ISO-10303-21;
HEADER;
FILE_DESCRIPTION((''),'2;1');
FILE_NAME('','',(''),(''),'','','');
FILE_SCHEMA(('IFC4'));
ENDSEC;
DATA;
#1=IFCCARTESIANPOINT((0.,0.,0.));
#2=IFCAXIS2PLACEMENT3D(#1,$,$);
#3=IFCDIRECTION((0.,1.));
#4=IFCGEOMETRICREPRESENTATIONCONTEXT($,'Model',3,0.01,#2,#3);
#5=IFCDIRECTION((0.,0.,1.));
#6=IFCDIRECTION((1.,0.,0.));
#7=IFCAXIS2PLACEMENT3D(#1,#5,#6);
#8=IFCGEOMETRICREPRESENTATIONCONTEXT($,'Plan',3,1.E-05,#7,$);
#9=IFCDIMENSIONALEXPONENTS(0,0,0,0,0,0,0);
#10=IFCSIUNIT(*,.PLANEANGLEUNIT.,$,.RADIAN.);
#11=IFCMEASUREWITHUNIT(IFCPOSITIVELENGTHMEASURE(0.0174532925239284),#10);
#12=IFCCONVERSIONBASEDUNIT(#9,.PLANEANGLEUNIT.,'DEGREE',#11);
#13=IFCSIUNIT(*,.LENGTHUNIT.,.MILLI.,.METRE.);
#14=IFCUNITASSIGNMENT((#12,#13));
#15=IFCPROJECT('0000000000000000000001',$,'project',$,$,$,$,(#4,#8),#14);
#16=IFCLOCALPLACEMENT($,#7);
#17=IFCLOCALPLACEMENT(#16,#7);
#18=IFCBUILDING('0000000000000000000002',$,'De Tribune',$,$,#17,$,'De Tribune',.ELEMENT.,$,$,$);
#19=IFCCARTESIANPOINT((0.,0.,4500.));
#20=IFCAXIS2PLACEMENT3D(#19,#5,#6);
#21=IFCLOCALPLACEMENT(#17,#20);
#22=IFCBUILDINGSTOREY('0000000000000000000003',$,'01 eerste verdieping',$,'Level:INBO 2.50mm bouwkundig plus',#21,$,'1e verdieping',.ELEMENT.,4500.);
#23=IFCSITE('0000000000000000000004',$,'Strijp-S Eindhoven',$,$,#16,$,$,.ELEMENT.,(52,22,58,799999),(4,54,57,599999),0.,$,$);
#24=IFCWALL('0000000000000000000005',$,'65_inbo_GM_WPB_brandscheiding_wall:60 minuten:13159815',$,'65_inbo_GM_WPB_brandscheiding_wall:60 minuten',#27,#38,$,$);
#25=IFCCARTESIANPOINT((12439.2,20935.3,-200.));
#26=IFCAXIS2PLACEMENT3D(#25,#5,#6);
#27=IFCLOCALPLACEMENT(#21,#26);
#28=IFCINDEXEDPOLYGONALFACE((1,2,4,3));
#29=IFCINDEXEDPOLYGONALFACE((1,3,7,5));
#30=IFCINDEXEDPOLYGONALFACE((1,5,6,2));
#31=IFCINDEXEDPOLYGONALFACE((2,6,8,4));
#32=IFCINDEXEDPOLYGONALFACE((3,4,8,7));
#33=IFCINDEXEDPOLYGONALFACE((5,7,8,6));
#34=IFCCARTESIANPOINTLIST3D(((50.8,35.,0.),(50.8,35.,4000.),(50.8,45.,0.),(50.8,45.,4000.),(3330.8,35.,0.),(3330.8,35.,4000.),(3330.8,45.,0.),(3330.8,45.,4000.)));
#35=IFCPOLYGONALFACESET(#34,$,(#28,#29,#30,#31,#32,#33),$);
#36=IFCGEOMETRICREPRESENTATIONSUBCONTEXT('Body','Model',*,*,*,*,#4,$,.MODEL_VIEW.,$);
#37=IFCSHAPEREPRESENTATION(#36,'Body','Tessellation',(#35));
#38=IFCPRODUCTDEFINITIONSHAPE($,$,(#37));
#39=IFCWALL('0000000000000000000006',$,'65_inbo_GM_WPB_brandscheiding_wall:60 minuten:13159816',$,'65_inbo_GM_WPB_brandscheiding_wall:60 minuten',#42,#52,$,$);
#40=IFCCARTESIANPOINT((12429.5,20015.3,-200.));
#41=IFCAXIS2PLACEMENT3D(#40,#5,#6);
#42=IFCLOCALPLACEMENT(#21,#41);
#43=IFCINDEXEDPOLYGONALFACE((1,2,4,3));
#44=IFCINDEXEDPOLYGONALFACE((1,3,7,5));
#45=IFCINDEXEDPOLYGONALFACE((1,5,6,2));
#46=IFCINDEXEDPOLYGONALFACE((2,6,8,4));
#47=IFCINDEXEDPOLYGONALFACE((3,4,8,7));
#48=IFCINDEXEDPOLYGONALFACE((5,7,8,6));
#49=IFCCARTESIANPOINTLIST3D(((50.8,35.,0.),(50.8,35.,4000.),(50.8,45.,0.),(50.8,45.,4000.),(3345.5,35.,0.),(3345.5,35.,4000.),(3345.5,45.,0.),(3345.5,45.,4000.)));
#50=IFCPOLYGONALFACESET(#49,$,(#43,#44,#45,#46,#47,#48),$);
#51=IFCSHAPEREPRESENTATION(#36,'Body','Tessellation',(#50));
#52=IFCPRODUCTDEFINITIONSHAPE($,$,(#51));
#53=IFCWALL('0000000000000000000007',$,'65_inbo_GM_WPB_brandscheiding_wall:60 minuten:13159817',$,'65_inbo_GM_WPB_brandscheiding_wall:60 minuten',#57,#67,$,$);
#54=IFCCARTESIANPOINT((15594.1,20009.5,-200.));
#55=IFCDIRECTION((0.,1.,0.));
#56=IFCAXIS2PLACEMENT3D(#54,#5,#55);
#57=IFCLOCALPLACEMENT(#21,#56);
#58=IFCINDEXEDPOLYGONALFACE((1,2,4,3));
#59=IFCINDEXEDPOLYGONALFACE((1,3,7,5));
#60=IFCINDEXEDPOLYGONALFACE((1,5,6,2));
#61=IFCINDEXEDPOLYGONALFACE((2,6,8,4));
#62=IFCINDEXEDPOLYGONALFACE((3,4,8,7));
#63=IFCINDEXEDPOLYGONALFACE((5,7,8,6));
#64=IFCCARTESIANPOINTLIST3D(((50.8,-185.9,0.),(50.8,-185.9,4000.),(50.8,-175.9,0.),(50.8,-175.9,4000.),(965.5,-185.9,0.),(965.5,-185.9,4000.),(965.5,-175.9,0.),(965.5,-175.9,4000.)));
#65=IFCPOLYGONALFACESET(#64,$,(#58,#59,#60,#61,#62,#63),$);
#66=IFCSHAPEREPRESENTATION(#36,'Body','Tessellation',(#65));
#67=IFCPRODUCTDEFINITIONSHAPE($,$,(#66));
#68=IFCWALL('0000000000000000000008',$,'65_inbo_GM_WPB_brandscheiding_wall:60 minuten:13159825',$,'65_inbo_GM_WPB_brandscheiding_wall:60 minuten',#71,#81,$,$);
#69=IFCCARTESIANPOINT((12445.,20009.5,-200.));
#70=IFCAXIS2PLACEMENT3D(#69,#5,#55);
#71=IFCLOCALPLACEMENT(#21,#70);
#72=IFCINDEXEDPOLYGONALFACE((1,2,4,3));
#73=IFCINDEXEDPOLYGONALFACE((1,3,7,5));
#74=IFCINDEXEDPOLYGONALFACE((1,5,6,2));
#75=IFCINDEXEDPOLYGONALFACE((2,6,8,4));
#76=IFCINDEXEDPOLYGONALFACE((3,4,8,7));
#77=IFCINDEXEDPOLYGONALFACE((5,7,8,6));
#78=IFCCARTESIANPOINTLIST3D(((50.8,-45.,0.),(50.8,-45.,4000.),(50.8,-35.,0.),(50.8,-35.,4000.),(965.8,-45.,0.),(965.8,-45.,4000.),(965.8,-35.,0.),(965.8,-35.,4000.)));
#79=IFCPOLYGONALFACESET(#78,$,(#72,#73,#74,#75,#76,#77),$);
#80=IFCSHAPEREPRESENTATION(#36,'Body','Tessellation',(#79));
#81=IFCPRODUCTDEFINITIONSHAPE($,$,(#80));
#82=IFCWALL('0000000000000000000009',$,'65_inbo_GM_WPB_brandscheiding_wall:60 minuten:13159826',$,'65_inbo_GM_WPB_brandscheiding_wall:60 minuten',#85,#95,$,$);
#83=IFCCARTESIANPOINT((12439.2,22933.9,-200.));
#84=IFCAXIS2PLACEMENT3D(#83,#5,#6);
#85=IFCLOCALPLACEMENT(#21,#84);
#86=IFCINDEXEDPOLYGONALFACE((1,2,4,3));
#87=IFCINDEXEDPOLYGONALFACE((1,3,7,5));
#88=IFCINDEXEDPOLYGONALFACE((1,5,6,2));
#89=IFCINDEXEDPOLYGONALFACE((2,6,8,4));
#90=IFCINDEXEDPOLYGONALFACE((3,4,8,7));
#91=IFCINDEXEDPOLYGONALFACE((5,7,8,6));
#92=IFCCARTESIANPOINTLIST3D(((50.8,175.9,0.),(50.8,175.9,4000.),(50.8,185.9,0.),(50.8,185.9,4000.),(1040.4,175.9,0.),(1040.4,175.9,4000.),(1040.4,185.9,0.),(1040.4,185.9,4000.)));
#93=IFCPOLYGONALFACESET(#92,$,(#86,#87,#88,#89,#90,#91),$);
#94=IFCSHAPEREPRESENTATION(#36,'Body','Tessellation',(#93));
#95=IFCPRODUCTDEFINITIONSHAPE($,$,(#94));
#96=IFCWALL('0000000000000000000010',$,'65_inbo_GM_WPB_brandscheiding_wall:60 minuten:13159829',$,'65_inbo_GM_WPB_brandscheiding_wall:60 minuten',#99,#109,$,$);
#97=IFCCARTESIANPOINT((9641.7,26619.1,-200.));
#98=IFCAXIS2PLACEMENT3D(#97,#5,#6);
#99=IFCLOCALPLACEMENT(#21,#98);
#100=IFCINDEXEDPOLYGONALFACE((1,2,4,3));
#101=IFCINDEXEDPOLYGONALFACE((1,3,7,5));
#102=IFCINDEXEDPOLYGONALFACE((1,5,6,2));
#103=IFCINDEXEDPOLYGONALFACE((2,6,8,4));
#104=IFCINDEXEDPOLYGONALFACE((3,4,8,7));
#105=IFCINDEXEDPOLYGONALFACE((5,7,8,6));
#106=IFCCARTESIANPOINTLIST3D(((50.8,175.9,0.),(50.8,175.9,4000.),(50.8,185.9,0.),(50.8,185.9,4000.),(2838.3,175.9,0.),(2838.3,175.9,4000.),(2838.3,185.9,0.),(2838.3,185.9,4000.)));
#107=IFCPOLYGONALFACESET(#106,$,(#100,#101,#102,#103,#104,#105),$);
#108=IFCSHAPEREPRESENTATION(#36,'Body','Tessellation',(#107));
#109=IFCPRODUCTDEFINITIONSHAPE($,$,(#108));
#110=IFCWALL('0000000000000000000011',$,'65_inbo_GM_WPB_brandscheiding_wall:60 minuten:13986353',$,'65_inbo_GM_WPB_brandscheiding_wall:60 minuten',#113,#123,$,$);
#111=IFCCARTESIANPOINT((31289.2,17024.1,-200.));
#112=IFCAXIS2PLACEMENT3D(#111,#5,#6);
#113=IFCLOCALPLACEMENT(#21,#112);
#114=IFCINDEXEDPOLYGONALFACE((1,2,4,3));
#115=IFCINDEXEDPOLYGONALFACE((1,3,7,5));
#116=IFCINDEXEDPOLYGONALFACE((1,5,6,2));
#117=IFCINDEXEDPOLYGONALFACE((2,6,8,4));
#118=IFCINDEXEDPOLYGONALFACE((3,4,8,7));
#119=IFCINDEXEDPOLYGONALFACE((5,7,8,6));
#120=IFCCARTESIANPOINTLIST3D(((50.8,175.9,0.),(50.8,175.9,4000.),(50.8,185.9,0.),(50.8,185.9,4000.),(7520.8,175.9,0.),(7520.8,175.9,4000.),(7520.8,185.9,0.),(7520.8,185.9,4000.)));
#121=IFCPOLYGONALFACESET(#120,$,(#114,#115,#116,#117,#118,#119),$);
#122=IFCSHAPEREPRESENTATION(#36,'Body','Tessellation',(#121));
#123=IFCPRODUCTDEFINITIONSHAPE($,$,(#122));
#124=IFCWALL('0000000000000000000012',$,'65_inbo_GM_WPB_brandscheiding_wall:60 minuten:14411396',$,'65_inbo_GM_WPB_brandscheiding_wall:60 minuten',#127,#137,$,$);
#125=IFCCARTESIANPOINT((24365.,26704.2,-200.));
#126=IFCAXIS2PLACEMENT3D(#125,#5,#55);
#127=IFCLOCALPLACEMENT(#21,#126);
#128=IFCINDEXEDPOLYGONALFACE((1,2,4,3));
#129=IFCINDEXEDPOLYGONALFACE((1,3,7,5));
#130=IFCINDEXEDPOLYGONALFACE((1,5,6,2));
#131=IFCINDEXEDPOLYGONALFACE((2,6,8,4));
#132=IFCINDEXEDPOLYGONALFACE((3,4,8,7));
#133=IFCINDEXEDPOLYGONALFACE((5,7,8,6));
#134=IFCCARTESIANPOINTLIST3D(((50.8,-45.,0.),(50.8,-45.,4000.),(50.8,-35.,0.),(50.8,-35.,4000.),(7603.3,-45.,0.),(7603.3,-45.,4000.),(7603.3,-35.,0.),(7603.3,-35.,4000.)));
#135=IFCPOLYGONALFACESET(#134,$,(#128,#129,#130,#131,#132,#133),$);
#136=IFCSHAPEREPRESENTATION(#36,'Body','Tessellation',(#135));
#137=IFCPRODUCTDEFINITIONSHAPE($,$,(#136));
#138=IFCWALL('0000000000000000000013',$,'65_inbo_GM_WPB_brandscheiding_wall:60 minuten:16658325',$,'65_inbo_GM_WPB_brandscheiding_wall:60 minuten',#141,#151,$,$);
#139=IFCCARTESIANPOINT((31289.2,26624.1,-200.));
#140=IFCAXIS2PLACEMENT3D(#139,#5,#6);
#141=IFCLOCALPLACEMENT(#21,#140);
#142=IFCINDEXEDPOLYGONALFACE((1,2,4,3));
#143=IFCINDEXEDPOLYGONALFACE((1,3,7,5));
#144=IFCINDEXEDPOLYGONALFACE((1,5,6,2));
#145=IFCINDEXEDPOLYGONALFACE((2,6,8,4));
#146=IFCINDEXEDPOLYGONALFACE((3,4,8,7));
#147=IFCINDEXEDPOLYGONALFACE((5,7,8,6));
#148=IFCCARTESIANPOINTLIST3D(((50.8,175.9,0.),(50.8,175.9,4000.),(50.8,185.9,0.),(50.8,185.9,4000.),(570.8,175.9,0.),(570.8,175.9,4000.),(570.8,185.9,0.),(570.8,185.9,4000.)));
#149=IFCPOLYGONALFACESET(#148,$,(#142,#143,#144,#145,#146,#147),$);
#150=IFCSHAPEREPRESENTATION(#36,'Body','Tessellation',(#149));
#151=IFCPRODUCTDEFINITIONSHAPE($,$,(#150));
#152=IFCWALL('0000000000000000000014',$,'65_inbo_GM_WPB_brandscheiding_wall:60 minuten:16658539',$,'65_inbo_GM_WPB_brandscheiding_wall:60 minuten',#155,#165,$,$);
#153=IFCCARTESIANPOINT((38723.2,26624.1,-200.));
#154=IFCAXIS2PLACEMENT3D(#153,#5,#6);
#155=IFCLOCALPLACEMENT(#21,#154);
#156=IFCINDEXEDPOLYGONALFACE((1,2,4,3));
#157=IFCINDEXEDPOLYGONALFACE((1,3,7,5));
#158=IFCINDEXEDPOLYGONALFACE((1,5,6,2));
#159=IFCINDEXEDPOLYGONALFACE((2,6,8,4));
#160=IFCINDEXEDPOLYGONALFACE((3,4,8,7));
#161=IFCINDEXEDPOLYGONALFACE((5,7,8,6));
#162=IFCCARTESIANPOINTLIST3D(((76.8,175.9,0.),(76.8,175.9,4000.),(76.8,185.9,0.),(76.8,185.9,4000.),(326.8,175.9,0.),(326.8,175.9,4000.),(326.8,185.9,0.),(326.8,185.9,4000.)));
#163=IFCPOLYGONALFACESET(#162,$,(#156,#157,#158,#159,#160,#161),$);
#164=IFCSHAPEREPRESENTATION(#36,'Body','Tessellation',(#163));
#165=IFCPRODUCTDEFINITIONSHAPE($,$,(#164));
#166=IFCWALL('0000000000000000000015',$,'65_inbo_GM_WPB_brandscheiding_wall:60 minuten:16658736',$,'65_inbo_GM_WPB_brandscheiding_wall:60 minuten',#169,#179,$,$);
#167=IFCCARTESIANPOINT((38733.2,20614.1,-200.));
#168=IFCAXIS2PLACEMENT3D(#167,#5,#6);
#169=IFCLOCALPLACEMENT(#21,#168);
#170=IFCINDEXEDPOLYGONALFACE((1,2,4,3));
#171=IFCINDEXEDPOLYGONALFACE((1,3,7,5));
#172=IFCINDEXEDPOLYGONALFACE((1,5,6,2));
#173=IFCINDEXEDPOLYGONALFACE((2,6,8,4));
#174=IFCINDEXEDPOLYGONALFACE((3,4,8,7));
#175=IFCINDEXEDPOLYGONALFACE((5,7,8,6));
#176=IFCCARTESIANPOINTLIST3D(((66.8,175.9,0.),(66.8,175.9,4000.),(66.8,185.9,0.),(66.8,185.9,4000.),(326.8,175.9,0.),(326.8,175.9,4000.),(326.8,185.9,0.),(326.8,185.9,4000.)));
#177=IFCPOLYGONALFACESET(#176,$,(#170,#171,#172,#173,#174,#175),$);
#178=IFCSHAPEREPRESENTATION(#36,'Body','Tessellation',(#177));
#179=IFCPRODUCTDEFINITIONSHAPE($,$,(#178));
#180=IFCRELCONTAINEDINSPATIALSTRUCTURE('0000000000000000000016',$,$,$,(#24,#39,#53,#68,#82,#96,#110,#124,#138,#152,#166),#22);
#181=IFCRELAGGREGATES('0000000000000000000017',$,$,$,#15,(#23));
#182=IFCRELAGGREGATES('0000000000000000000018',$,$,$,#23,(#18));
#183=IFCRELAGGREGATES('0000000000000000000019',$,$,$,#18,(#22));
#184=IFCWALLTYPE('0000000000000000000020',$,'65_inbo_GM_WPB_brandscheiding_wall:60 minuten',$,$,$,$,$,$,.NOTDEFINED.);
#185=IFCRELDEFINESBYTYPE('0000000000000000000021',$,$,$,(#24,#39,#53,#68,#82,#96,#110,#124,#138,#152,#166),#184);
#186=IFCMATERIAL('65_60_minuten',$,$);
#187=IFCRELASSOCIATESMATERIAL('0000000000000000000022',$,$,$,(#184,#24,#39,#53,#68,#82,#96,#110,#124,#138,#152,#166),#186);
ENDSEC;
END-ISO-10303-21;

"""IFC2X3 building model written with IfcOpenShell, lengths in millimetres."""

from ifc_helpers import new_model, entity, si_unit, converted_unit, direction, frame, frame_2d, origin, origin_with_axes, origin_2d_with_axis, place, context, subcontext, project, spatial, rectangle, extrude, material, type_object, element, save


model = new_model("IFC2X3")

# Units and contexts
model_context = context("Model", 3, precision=0.01, world=origin(), true_north=direction((0.0, 1.0)))
plan_context = context("Plan", 3, precision=1e-05, world=origin_with_axes())
body_context = subcontext(model_context, "Body", "Model", "MODEL_VIEW")
ifc_project = project(units=[converted_unit("PLANEANGLEUNIT", "DEGREE", entity("IfcPositiveLengthMeasure", 0.0174532925239284), si_unit("PLANEANGLEUNIT", "RADIAN"), dimensions=[0, 0, 0, 0, 0, 0, 0]), si_unit("LENGTHUNIT", "METRE", prefix="MILLI")], contexts=[model_context, plan_context])

# Site, building, storey
site_placement = place(None, origin_with_axes())
site = spatial("IfcSite", under=ifc_project, at=site_placement, Name="Strijp-S Eindhoven", CompositionType="ELEMENT", RefLatitude=(52, 22, 58, 799999), RefLongitude=(4, 54, 57, 599999), RefElevation=0.0)
building_placement = place(site_placement, origin_with_axes())
building = spatial("IfcBuilding", under=site, at=building_placement, Name="De Tribune", LongName="De Tribune", CompositionType="ELEMENT")
storey_placement = place(building_placement, frame((0.0, 0.0, 4500.0), z_axis=(0.0, 0.0, 1.0), x_axis=(1.0, 0.0, 0.0)))
storey = spatial("IfcBuildingStorey", under=building, at=storey_placement, Name="01 eerste verdieping", ObjectType="Level:INBO 2.50mm bouwkundig plus", LongName="1e verdieping", CompositionType="ELEMENT", Elevation=4500.0)

# Walls
ifc_material_1 = material(Name="65_60_minuten")
wall_type_1 = type_object("IfcWallType", Name="65_inbo_GM_WPB_brandscheiding_wall:60 minuten", PredefinedType="NOTDEFINED", material=ifc_material_1)
wall_1_placement = place(storey_placement, frame((12439.2, 20935.3, -200.0), z_axis=(0.0, 0.0, 1.0), x_axis=(1.0, 0.0, 0.0)))
element("IfcWall", 1, at=wall_1_placement, inside=storey, type_object=wall_type_1, material=ifc_material_1, Name="65_inbo_GM_WPB_brandscheiding_wall:60 minuten:13159815", ObjectType="65_inbo_GM_WPB_brandscheiding_wall:60 minuten", context=body_context, shape_type="SweptSolid", body=[
    extrude(rectangle(XDim=10.0, YDim=3280.0, at=frame_2d((0.0, 0.0), x_axis=(1.0, 0.0))), frame((1690.8, 40.0, 0.0), z_axis=(0.0, 0.0, 1.0), x_axis=(0.0, 1.0, 0.0)), (0.0, 0.0, 1.0), 4000.0),
])
wall_2_placement = place(storey_placement, frame((12429.5, 20015.3, -200.0), z_axis=(0.0, 0.0, 1.0), x_axis=(1.0, 0.0, 0.0)))
element("IfcWall", 2, at=wall_2_placement, inside=storey, type_object=wall_type_1, material=ifc_material_1, Name="65_inbo_GM_WPB_brandscheiding_wall:60 minuten:13159816", ObjectType="65_inbo_GM_WPB_brandscheiding_wall:60 minuten", context=body_context, shape_type="SweptSolid", body=[
    extrude(rectangle(XDim=10.0, YDim=3294.7, at=frame_2d((0.0, 0.0), x_axis=(1.0, 0.0))), frame((1698.2, 40.0, 0.0), z_axis=(0.0, 0.0, 1.0), x_axis=(0.0, 1.0, 0.0)), (0.0, 0.0, 1.0), 4000.0),
])
wall_3_placement = place(storey_placement, frame((15594.1, 20009.5, -200.0), z_axis=(0.0, 0.0, 1.0), x_axis=(0.0, 1.0, 0.0)))
element("IfcWall", 3, at=wall_3_placement, inside=storey, type_object=wall_type_1, material=ifc_material_1, Name="65_inbo_GM_WPB_brandscheiding_wall:60 minuten:13159817", ObjectType="65_inbo_GM_WPB_brandscheiding_wall:60 minuten", context=body_context, shape_type="SweptSolid", body=[
    extrude(rectangle(XDim=10.0, YDim=914.7, at=origin_2d_with_axis()), frame((508.2, -180.9, 0.0), z_axis=(0.0, 0.0, 1.0), x_axis=(0.0, 1.0, 0.0)), (0.0, 0.0, 1.0), 4000.0),
])
wall_4_placement = place(storey_placement, frame((12445.0, 20009.5, -200.0), z_axis=(0.0, 0.0, 1.0), x_axis=(0.0, 1.0, 0.0)))
element("IfcWall", 4, at=wall_4_placement, inside=storey, type_object=wall_type_1, material=ifc_material_1, Name="65_inbo_GM_WPB_brandscheiding_wall:60 minuten:13159825", ObjectType="65_inbo_GM_WPB_brandscheiding_wall:60 minuten", context=body_context, shape_type="SweptSolid", body=[
    extrude(rectangle(XDim=915.0, YDim=10.0, at=frame_2d((0.0, 0.0), x_axis=(1.0, 0.0))), frame((508.3, -40.0, 0.0), z_axis=(0.0, 0.0, 1.0), x_axis=(-1.0, 0.0, 0.0)), (0.0, 0.0, 1.0), 4000.0),
])
wall_5_placement = place(storey_placement, frame((12439.2, 22933.9, -200.0), z_axis=(0.0, 0.0, 1.0), x_axis=(1.0, 0.0, 0.0)))
element("IfcWall", 5, at=wall_5_placement, inside=storey, type_object=wall_type_1, material=ifc_material_1, Name="65_inbo_GM_WPB_brandscheiding_wall:60 minuten:13159826", ObjectType="65_inbo_GM_WPB_brandscheiding_wall:60 minuten", context=body_context, shape_type="SweptSolid", body=[
    extrude(rectangle(XDim=989.6, YDim=10.0, at=frame_2d((0.0, 0.0), x_axis=(1.0, 0.0))), frame((545.6, 180.9, 0.0), z_axis=(0.0, 0.0, 1.0), x_axis=(-1.0, 0.0, 0.0)), (0.0, 0.0, 1.0), 4000.0),
])
wall_6_placement = place(storey_placement, frame((9641.7, 26619.1, -200.0), z_axis=(0.0, 0.0, 1.0), x_axis=(1.0, 0.0, 0.0)))
element("IfcWall", 6, at=wall_6_placement, inside=storey, type_object=wall_type_1, material=ifc_material_1, Name="65_inbo_GM_WPB_brandscheiding_wall:60 minuten:13159829", ObjectType="65_inbo_GM_WPB_brandscheiding_wall:60 minuten", context=body_context, shape_type="SweptSolid", body=[
    extrude(rectangle(XDim=2787.5, YDim=10.0, at=frame_2d((0.0, 0.0), x_axis=(1.0, 0.0))), frame((1444.6, 180.9, 0.0), z_axis=(0.0, 0.0, 1.0), x_axis=(-1.0, 0.0, 0.0)), (0.0, 0.0, 1.0), 4000.0),
])
wall_7_placement = place(storey_placement, frame((31289.2, 17024.1, -200.0), z_axis=(0.0, 0.0, 1.0), x_axis=(1.0, 0.0, 0.0)))
element("IfcWall", 7, at=wall_7_placement, inside=storey, type_object=wall_type_1, material=ifc_material_1, Name="65_inbo_GM_WPB_brandscheiding_wall:60 minuten:13986353", ObjectType="65_inbo_GM_WPB_brandscheiding_wall:60 minuten", context=body_context, shape_type="SweptSolid", body=[
    extrude(rectangle(XDim=7470.0, YDim=10.0, at=origin_2d_with_axis()), frame((3785.8, 180.9, 0.0), z_axis=(0.0, 0.0, 1.0), x_axis=(-1.0, 0.0, 0.0)), (0.0, 0.0, 1.0), 4000.0),
])
wall_8_placement = place(storey_placement, frame((24365.0, 26704.2, -200.0), z_axis=(0.0, 0.0, 1.0), x_axis=(0.0, 1.0, 0.0)))
element("IfcWall", 8, at=wall_8_placement, inside=storey, type_object=wall_type_1, material=ifc_material_1, Name="65_inbo_GM_WPB_brandscheiding_wall:60 minuten:14411396", ObjectType="65_inbo_GM_WPB_brandscheiding_wall:60 minuten", context=body_context, shape_type="SweptSolid", body=[
    extrude(rectangle(XDim=7552.5, YDim=10.0, at=origin_2d_with_axis()), frame((3827.1, -40.0, 0.0), z_axis=(0.0, 0.0, 1.0), x_axis=(-1.0, 0.0, 0.0)), (0.0, 0.0, 1.0), 4000.0),
])
wall_9_placement = place(storey_placement, frame((31289.2, 26624.1, -200.0), z_axis=(0.0, 0.0, 1.0), x_axis=(1.0, 0.0, 0.0)))
element("IfcWall", 9, at=wall_9_placement, inside=storey, type_object=wall_type_1, material=ifc_material_1, Name="65_inbo_GM_WPB_brandscheiding_wall:60 minuten:16658325", ObjectType="65_inbo_GM_WPB_brandscheiding_wall:60 minuten", context=body_context, shape_type="SweptSolid", body=[
    extrude(rectangle(XDim=520.0, YDim=10.0, at=frame_2d((0.0, 0.0), x_axis=(1.0, 0.0))), frame((310.8, 180.9, 0.0), z_axis=(0.0, 0.0, 1.0), x_axis=(-1.0, 0.0, 0.0)), (0.0, 0.0, 1.0), 4000.0),
])
wall_10_placement = place(storey_placement, frame((38723.2, 26624.1, -200.0), z_axis=(0.0, 0.0, 1.0), x_axis=(1.0, 0.0, 0.0)))
element("IfcWall", 10, at=wall_10_placement, inside=storey, type_object=wall_type_1, material=ifc_material_1, Name="65_inbo_GM_WPB_brandscheiding_wall:60 minuten:16658539", ObjectType="65_inbo_GM_WPB_brandscheiding_wall:60 minuten", context=body_context, shape_type="SweptSolid", body=[
    extrude(rectangle(XDim=250.0, YDim=10.0, at=frame_2d((0.0, 0.0), x_axis=(1.0, 0.0))), frame((201.8, 180.9, 0.0), z_axis=(0.0, 0.0, 1.0), x_axis=(-1.0, 0.0, 0.0)), (0.0, 0.0, 1.0), 4000.0),
])
wall_11_placement = place(storey_placement, frame((38733.2, 20614.1, -200.0), z_axis=(0.0, 0.0, 1.0), x_axis=(1.0, 0.0, 0.0)))
element("IfcWall", 11, at=wall_11_placement, inside=storey, type_object=wall_type_1, material=ifc_material_1, Name="65_inbo_GM_WPB_brandscheiding_wall:60 minuten:16658736", ObjectType="65_inbo_GM_WPB_brandscheiding_wall:60 minuten", context=body_context, shape_type="SweptSolid", body=[
    extrude(rectangle(XDim=260.0, YDim=10.0, at=frame_2d((0.0, 0.0), x_axis=(1.0, 0.0))), frame((196.8, 180.9, 0.0), z_axis=(0.0, 0.0, 1.0), x_axis=(-1.0, 0.0, 0.0)), (0.0, 0.0, 1.0), 4000.0),
])

save(model, "model.ifc")
